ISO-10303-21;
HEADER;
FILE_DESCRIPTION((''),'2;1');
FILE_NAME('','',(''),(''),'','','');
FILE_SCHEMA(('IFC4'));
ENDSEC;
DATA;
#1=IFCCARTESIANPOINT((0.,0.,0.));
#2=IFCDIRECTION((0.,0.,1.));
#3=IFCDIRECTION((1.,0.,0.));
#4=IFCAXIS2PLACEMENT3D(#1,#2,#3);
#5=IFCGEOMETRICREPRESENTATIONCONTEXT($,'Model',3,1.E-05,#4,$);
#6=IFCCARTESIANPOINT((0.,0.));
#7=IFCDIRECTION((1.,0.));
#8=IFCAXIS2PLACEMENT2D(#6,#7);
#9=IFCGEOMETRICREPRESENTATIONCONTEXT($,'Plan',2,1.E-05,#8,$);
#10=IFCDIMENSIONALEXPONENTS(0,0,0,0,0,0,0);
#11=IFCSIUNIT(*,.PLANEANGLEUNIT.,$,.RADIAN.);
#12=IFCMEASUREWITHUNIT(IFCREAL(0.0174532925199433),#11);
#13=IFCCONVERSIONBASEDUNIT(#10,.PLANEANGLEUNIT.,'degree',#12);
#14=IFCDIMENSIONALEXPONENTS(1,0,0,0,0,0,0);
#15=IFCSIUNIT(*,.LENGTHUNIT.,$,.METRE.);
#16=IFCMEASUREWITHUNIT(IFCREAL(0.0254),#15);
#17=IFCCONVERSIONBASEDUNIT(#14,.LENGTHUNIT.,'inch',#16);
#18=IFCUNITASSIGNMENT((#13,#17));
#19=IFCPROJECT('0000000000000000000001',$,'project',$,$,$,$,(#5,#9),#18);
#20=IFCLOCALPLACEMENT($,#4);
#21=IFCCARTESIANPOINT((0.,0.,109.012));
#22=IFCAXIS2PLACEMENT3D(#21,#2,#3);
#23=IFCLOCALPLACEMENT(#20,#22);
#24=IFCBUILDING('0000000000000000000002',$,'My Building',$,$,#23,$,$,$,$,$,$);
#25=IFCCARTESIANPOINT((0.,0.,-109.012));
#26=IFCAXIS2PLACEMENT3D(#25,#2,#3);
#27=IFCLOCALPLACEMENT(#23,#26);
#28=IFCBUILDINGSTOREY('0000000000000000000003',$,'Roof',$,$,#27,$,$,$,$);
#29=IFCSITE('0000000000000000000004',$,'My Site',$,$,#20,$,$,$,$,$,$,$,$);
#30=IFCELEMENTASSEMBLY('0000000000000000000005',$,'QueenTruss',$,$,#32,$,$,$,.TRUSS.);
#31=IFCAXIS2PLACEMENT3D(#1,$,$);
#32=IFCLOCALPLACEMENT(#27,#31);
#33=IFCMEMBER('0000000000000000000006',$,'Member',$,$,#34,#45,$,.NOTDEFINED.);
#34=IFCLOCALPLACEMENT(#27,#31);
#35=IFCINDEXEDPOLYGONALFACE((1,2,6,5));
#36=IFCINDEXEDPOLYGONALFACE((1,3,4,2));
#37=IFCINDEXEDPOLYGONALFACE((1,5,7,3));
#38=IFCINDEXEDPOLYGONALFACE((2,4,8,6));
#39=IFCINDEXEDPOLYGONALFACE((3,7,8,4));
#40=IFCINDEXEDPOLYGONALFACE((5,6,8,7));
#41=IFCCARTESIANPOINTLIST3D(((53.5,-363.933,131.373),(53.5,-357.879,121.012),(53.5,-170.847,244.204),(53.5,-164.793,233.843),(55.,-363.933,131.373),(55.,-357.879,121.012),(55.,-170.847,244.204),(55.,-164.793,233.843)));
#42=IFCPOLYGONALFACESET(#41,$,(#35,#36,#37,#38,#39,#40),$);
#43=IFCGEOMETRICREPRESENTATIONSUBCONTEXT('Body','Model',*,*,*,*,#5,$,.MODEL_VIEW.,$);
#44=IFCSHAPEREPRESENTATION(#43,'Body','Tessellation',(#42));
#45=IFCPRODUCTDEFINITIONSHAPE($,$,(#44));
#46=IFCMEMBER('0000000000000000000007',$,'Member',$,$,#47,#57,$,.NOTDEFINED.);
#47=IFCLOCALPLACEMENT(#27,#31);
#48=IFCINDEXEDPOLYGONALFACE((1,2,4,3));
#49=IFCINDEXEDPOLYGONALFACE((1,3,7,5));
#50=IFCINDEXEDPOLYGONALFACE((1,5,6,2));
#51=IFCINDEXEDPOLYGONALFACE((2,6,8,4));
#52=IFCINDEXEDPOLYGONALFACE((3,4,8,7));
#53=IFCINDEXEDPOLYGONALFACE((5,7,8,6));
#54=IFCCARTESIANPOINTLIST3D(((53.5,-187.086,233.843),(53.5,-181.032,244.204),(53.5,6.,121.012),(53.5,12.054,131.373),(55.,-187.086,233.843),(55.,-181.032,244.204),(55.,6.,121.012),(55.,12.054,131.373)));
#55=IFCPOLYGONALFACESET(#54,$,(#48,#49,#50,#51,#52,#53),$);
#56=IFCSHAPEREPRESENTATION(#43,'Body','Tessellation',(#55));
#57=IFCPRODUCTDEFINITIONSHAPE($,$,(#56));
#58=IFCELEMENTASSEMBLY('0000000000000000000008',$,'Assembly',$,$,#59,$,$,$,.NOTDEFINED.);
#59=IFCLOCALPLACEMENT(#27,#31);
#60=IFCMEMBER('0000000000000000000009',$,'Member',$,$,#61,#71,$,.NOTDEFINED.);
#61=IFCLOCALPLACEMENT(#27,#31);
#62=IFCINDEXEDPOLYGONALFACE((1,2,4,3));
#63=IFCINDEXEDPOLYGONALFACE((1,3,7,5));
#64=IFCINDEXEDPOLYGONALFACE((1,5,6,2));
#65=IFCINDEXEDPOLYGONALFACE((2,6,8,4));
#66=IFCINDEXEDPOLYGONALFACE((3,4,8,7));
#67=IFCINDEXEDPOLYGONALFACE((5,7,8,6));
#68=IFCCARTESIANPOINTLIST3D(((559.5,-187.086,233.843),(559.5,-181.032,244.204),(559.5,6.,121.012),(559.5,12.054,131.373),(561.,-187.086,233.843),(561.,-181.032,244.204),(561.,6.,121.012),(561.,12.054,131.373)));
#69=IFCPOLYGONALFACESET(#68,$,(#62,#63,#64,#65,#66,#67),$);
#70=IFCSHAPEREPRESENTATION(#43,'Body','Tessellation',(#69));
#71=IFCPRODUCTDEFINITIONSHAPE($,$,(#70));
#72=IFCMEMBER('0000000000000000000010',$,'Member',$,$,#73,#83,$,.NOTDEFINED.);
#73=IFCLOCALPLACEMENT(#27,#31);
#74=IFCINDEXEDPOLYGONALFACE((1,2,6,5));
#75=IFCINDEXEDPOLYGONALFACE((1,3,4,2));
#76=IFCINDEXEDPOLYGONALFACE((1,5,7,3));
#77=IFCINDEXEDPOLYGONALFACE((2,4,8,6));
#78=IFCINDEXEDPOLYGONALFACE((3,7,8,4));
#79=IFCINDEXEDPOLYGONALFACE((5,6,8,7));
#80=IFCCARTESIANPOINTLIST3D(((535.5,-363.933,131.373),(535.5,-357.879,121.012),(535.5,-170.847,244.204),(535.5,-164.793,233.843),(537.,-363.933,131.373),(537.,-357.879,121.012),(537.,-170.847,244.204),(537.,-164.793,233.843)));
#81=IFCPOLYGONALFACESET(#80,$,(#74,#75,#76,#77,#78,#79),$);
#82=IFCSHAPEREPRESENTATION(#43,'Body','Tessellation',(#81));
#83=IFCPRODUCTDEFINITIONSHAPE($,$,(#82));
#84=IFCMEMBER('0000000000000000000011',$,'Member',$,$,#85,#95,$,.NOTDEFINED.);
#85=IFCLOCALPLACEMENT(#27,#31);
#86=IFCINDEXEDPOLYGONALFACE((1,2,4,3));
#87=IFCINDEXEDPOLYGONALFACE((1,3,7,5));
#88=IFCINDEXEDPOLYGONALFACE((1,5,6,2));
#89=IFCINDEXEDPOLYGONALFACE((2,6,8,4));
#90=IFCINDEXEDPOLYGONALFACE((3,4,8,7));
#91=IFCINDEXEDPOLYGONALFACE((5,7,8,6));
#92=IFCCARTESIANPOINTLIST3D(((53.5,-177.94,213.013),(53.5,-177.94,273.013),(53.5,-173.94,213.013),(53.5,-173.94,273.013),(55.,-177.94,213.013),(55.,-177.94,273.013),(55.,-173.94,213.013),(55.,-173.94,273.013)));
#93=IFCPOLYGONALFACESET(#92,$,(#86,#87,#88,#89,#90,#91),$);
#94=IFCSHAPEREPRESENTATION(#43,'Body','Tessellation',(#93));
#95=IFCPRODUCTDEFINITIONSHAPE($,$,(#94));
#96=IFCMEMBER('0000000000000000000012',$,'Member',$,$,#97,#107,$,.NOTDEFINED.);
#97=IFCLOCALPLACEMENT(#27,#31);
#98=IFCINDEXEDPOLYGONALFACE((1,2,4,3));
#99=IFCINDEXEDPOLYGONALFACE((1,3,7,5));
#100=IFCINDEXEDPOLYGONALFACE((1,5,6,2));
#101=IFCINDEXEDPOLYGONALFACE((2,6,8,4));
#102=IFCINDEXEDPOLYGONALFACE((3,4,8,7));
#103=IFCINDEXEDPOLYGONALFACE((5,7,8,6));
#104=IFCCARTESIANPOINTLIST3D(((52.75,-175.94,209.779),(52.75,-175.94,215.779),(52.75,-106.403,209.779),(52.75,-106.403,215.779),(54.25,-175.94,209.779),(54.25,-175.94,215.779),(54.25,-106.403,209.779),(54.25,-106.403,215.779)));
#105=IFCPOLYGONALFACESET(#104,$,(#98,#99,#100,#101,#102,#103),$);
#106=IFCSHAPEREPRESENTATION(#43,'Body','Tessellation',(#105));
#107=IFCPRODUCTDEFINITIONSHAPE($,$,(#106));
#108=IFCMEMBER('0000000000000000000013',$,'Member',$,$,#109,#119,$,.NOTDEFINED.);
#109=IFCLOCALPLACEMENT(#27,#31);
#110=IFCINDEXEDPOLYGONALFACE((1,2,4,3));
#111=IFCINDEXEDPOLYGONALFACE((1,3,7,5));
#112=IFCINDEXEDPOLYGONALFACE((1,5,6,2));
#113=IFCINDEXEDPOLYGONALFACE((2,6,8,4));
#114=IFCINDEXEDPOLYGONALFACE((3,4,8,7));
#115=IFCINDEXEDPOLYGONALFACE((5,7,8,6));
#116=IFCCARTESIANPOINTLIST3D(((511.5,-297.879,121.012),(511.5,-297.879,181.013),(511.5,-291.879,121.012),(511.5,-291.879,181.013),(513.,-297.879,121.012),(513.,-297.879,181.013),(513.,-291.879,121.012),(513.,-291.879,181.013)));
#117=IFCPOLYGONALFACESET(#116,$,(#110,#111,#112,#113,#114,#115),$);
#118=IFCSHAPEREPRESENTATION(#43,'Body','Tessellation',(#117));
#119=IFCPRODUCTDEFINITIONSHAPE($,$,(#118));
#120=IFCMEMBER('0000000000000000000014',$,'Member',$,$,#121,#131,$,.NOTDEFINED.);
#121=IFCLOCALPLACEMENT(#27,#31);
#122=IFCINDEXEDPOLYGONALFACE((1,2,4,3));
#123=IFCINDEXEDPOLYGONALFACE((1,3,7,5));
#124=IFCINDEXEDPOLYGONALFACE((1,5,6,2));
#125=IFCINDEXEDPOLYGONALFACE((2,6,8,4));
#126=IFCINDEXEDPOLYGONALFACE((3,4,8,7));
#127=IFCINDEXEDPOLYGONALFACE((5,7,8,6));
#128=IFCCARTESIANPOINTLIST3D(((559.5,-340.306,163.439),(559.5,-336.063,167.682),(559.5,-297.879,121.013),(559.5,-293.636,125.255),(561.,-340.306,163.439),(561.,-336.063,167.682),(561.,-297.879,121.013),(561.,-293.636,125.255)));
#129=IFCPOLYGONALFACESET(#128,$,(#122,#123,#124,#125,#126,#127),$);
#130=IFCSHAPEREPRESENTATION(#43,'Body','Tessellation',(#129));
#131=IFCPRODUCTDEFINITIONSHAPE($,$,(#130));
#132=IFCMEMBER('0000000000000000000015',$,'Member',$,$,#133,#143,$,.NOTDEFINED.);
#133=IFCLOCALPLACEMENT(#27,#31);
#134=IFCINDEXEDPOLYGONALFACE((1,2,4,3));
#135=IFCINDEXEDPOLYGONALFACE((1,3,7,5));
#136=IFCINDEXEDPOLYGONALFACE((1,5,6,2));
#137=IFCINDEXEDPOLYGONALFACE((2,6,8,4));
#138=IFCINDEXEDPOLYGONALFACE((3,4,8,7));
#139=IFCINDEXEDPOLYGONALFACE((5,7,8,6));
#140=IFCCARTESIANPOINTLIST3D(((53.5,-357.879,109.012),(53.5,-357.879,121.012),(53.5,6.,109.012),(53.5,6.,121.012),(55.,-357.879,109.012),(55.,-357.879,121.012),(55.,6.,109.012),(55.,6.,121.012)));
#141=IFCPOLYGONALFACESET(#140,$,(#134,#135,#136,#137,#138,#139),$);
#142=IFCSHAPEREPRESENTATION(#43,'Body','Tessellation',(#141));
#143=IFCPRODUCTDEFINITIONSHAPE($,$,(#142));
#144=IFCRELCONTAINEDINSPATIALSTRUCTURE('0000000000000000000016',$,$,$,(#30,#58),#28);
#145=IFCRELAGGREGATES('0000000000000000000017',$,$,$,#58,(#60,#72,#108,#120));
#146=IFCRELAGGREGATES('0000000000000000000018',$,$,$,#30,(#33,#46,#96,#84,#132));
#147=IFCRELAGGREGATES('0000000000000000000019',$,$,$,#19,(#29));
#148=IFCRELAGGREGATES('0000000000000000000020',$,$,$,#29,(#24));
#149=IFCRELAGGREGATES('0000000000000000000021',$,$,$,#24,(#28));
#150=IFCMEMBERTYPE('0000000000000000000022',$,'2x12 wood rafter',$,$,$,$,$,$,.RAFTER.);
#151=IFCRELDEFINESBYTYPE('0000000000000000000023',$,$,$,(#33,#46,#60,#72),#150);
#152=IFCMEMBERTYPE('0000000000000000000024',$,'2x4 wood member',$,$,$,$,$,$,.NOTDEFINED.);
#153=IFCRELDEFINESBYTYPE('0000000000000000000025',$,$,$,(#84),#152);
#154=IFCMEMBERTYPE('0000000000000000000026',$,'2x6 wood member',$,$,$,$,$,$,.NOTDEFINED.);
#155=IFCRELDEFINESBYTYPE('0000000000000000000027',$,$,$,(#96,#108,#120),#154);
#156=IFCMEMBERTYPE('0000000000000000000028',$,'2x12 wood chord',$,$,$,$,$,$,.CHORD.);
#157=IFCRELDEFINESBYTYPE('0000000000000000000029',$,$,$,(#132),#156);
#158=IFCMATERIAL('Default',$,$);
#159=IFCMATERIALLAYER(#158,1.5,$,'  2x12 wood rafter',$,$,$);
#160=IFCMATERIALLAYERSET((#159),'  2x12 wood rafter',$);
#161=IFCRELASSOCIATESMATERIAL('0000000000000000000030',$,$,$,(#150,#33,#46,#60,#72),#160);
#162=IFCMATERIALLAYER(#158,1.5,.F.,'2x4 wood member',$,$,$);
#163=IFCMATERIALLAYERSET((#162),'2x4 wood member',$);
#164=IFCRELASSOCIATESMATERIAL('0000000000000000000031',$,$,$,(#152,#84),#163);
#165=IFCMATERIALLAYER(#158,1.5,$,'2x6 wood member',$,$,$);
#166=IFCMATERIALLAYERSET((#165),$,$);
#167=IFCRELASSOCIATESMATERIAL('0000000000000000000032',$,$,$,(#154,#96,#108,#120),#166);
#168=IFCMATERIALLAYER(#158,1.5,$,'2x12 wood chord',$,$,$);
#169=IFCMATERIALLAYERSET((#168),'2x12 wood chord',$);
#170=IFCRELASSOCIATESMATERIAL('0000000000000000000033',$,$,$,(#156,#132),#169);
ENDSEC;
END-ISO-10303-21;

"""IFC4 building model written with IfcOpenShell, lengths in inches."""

from ifc_helpers import new_model, entity, si_unit, converted_unit, frame, origin_with_axes, origin_2d_with_axis, place, context, subcontext, project, spatial, indexed_curve, outline, extrude, material, layer, layer_set, layer_usage, type_object, element, aggregate, save


model = new_model("IFC4")

# Units and contexts
model_context = context("Model", 3, precision=1e-05, world=origin_with_axes())
plan_context = context("Plan", 2, precision=1e-05, world=origin_2d_with_axis())
body_context = subcontext(model_context, "Body", "Model", "MODEL_VIEW")
ifc_project = project(units=[converted_unit("PLANEANGLEUNIT", "degree", entity("IfcReal", 0.0174532925199433), si_unit("PLANEANGLEUNIT", "RADIAN"), dimensions=[0, 0, 0, 0, 0, 0, 0]), converted_unit("LENGTHUNIT", "inch", entity("IfcReal", 0.0254), si_unit("LENGTHUNIT", "METRE"), dimensions=[1, 0, 0, 0, 0, 0, 0])], contexts=[model_context, plan_context])

# Site, building, storey
site_placement = place(None, origin_with_axes())
site = spatial("IfcSite", under=ifc_project, at=site_placement, Name="My Site")
building_placement = place(site_placement, frame((0.0, 0.0, 109.012), z_axis=(0.0, 0.0, 1.0), x_axis=(1.0, 0.0, 0.0)))
building = spatial("IfcBuilding", under=site, at=building_placement, Name="My Building")
storey_placement = place(building_placement, frame((0.0, 0.0, -109.012), z_axis=(0.0, 0.0, 1.0), x_axis=(1.0, 0.0, 0.0)))
storey = spatial("IfcBuildingStorey", under=building, at=storey_placement, Name="Roof")

# Element assemblies, members
assembly_1_placement = place(storey_placement, frame((53.5, -175.94, 109.012), z_axis=(0.0, 0.0, 1.0), x_axis=(1.0, 0.0, 0.0)))
assembly_1 = element("IfcElementAssembly", 1, at=assembly_1_placement, inside=storey, Name="QueenTruss", PredefinedType="TRUSS")
ifc_material = material(Name="Default")
ifc_layer_1 = layer(ifc_material, 1.5, Name="  2x12 wood rafter")
ifc_layer_set_1 = layer_set([ifc_layer_1], Name="  2x12 wood rafter")
ifc_layer_usage_1 = layer_usage(ifc_layer_set_1, "AXIS2", "POSITIVE", 0.0)
member_type_1 = type_object("IfcMemberType", Name="2x12 wood rafter", PredefinedType="RAFTER", material=ifc_layer_set_1)
member_1_placement = place(assembly_1_placement, frame((1.5, -181.94, 12.0), z_axis=(0.0, -0.504528, 0.863396), x_axis=(0.000001, 0.863396, 0.504528)))
member_1 = element("IfcMember", 2, at=member_1_placement, type_object=member_type_1, material=ifc_layer_usage_1, Name="Member", PredefinedType="NOTDEFINED", context=body_context, shape_type="SweptSolid", body=[
    extrude(outline(indexed_curve([(0.0, 0.0), (0.0, 1.5), (223.636, 1.5), (223.636, 0.0), (0.0, 0.0)], self_intersect=False)), origin_with_axes(), (0.0, 0.0, 1.0), 12.0),
])
ifc_layer_usage_2 = layer_usage(ifc_layer_set_1, "AXIS2", "POSITIVE", 0.0)
member_2_placement = place(assembly_1_placement, frame((0.0, 181.94, 12.0), z_axis=(0.0, 0.504528, 0.863396), x_axis=(-0.000001, -0.863396, 0.504528)))
member_2 = element("IfcMember", 3, at=member_2_placement, type_object=member_type_1, material=ifc_layer_usage_2, Name="Member", PredefinedType="NOTDEFINED", context=body_context, shape_type="SweptSolid", body=[
    extrude(outline(indexed_curve([(0.0, 0.0), (0.0, 1.5), (223.636, 1.5), (223.636, 0.0), (0.0, 0.0)], self_intersect=False)), origin_with_axes(), (0.0, 0.0, 1.0), 12.0),
])
assembly_2_placement = place(storey_placement, origin_with_axes())
assembly_2 = element("IfcElementAssembly", 4, at=assembly_2_placement, inside=storey, Name="Assembly", PredefinedType="NOTDEFINED")
ifc_layer_usage_3 = layer_usage(ifc_layer_set_1, "AXIS2", "POSITIVE", 0.0)
member_3_placement = place(assembly_2_placement, frame((559.5, 6.0, 121.012), z_axis=(0.0, 0.504528, 0.863396), x_axis=(-0.000001, -0.863396, 0.504528)))
member_3 = element("IfcMember", 5, at=member_3_placement, type_object=member_type_1, material=ifc_layer_usage_3, Name="Member", PredefinedType="NOTDEFINED", context=body_context, shape_type="SweptSolid", body=[
    extrude(outline(indexed_curve([(0.0, 0.0), (0.0, 1.5), (223.636, 1.5), (223.636, 0.0), (0.0, 0.0)], self_intersect=False)), origin_with_axes(), (0.0, 0.0, 1.0), 12.0),
])
ifc_layer_usage_4 = layer_usage(ifc_layer_set_1, "AXIS2", "POSITIVE", 0.0)
member_4_placement = place(assembly_2_placement, frame((537.0, -357.879, 121.012), z_axis=(0.0, -0.504528, 0.863396), x_axis=(0.000001, 0.863396, 0.504528)))
member_4 = element("IfcMember", 6, at=member_4_placement, type_object=member_type_1, material=ifc_layer_usage_4, Name="Member", PredefinedType="NOTDEFINED", context=body_context, shape_type="SweptSolid", body=[
    extrude(outline(indexed_curve([(0.0, 0.0), (0.0, 1.5), (223.636, 1.5), (223.636, 0.0), (0.0, 0.0)], self_intersect=False)), origin_with_axes(), (0.0, 0.0, 1.0), 12.0),
])

# Members
ifc_layer_2 = layer(ifc_material, 1.5, ventilated=False, Name="2x4 wood member")
ifc_layer_set_2 = layer_set([ifc_layer_2], Name="2x4 wood member")
ifc_layer_usage_5 = layer_usage(ifc_layer_set_2, "AXIS2", "POSITIVE", 0.0)
member_type_2 = type_object("IfcMemberType", Name="2x4 wood member", PredefinedType="NOTDEFINED", material=ifc_layer_set_2)
member_5_placement = place(assembly_1_placement, frame((1.5, 2.0, 104.0), z_axis=(0.0, -1.0, 0.0), x_axis=(0.0, 0.0, 1.0)))
member_5 = element("IfcMember", 7, at=member_5_placement, type_object=member_type_2, material=ifc_layer_usage_5, Name="Member", PredefinedType="NOTDEFINED", context=body_context, shape_type="SweptSolid", body=[
    extrude(outline(indexed_curve([(0.0, 0.0), (0.0, 1.5), (60.0, 1.5), (60.0, 0.0), (0.0, 0.0)], self_intersect=False)), origin_with_axes(), (0.0, 0.0, 1.0), 4.0),
])
ifc_layer_3 = layer(ifc_material, 1.5, Name="2x6 wood member")
ifc_layer_set_3 = layer_set([ifc_layer_3])
member_type_3 = type_object("IfcMemberType", Name="2x6 wood member", PredefinedType="NOTDEFINED", material=ifc_layer_set_3)
ifc_layer_usage_6 = layer_usage(ifc_layer_set_3, "AXIS2", "POSITIVE", 0.0)
member_6_placement = place(assembly_1_placement, frame((0.75, 0.0, 100.767), z_axis=(0.0, 0.0, 1.0), x_axis=(0.0, 1.0, 0.0)))
member_6 = element("IfcMember", 8, at=member_6_placement, type_object=member_type_3, material=ifc_layer_usage_6, Name="Member", PredefinedType="NOTDEFINED", context=body_context, shape_type="SweptSolid", body=[
    extrude(outline(indexed_curve([(0.0, 0.0), (0.0, 1.5), (69.536, 1.5), (69.536, 0.0), (0.0, 0.0)], self_intersect=False)), origin_with_axes(), (0.0, 0.0, 1.0), 6.0),
])
ifc_layer_usage_7 = layer_usage(ifc_layer_set_3, "AXIS2", "POSITIVE", 0.0)
member_7_placement = place(assembly_2_placement, frame((513.0, -291.879, 121.012), z_axis=(0.0, -1.0, 0.0), x_axis=(0.0, 0.0, 1.0)))
member_7 = element("IfcMember", 9, at=member_7_placement, type_object=member_type_3, material=ifc_layer_usage_7, Name="Member", PredefinedType="NOTDEFINED", context=body_context, shape_type="SweptSolid", body=[
    extrude(outline(indexed_curve([(0.0, 0.0), (0.0, 1.5), (60.0, 1.5), (60.0, 0.0), (0.0, 0.0)], self_intersect=False)), origin_with_axes(), (0.0, 0.0, 1.0), 6.0),
])
ifc_layer_usage_8 = layer_usage(ifc_layer_set_3, "AXIS2", "POSITIVE", 0.0)
member_8_placement = place(assembly_2_placement, frame((561.0, -293.636, 125.255), z_axis=(0.0, -0.707107, -0.707107), x_axis=(0.0, -0.707107, 0.707107)))
member_8 = element("IfcMember", 10, at=member_8_placement, type_object=member_type_3, material=ifc_layer_usage_8, Name="Member", PredefinedType="NOTDEFINED", context=body_context, shape_type="SweptSolid", body=[
    extrude(outline(indexed_curve([(0.0, 0.0), (0.0, 1.5), (60.0, 1.5), (60.0, 0.0), (0.0, 0.0)], self_intersect=False)), origin_with_axes(), (0.0, 0.0, 1.0), 6.0),
])
aggregate(assembly_2, [member_3, member_4, member_7, member_8])
ifc_layer_4 = layer(ifc_material, 1.5, Name="2x12 wood chord")
ifc_layer_set_4 = layer_set([ifc_layer_4], Name="2x12 wood chord")
ifc_layer_usage_9 = layer_usage(ifc_layer_set_4, "AXIS2", "POSITIVE", 0.0)
member_type_4 = type_object("IfcMemberType", Name="2x12 wood chord", PredefinedType="CHORD", material=ifc_layer_set_4)
member_9_placement = place(assembly_1_placement, frame((1.5, -181.94, 0.0), z_axis=(0.0, 0.0, 1.0), x_axis=(0.0, 1.0, 0.0)))
member_9 = element("IfcMember", 11, at=member_9_placement, type_object=member_type_4, material=ifc_layer_usage_9, Name="Member", PredefinedType="NOTDEFINED", context=body_context, shape_type="SweptSolid", body=[
    extrude(outline(indexed_curve([(0.0, 0.0), (0.0, 1.5), (363.879, 1.5), (363.879, 0.0), (0.0, 0.0)], self_intersect=False)), origin_with_axes(), (0.0, 0.0, 1.0), 12.0),
])
aggregate(assembly_1, [member_1, member_2, member_6, member_5, member_9])

save(model, "model.ifc")
